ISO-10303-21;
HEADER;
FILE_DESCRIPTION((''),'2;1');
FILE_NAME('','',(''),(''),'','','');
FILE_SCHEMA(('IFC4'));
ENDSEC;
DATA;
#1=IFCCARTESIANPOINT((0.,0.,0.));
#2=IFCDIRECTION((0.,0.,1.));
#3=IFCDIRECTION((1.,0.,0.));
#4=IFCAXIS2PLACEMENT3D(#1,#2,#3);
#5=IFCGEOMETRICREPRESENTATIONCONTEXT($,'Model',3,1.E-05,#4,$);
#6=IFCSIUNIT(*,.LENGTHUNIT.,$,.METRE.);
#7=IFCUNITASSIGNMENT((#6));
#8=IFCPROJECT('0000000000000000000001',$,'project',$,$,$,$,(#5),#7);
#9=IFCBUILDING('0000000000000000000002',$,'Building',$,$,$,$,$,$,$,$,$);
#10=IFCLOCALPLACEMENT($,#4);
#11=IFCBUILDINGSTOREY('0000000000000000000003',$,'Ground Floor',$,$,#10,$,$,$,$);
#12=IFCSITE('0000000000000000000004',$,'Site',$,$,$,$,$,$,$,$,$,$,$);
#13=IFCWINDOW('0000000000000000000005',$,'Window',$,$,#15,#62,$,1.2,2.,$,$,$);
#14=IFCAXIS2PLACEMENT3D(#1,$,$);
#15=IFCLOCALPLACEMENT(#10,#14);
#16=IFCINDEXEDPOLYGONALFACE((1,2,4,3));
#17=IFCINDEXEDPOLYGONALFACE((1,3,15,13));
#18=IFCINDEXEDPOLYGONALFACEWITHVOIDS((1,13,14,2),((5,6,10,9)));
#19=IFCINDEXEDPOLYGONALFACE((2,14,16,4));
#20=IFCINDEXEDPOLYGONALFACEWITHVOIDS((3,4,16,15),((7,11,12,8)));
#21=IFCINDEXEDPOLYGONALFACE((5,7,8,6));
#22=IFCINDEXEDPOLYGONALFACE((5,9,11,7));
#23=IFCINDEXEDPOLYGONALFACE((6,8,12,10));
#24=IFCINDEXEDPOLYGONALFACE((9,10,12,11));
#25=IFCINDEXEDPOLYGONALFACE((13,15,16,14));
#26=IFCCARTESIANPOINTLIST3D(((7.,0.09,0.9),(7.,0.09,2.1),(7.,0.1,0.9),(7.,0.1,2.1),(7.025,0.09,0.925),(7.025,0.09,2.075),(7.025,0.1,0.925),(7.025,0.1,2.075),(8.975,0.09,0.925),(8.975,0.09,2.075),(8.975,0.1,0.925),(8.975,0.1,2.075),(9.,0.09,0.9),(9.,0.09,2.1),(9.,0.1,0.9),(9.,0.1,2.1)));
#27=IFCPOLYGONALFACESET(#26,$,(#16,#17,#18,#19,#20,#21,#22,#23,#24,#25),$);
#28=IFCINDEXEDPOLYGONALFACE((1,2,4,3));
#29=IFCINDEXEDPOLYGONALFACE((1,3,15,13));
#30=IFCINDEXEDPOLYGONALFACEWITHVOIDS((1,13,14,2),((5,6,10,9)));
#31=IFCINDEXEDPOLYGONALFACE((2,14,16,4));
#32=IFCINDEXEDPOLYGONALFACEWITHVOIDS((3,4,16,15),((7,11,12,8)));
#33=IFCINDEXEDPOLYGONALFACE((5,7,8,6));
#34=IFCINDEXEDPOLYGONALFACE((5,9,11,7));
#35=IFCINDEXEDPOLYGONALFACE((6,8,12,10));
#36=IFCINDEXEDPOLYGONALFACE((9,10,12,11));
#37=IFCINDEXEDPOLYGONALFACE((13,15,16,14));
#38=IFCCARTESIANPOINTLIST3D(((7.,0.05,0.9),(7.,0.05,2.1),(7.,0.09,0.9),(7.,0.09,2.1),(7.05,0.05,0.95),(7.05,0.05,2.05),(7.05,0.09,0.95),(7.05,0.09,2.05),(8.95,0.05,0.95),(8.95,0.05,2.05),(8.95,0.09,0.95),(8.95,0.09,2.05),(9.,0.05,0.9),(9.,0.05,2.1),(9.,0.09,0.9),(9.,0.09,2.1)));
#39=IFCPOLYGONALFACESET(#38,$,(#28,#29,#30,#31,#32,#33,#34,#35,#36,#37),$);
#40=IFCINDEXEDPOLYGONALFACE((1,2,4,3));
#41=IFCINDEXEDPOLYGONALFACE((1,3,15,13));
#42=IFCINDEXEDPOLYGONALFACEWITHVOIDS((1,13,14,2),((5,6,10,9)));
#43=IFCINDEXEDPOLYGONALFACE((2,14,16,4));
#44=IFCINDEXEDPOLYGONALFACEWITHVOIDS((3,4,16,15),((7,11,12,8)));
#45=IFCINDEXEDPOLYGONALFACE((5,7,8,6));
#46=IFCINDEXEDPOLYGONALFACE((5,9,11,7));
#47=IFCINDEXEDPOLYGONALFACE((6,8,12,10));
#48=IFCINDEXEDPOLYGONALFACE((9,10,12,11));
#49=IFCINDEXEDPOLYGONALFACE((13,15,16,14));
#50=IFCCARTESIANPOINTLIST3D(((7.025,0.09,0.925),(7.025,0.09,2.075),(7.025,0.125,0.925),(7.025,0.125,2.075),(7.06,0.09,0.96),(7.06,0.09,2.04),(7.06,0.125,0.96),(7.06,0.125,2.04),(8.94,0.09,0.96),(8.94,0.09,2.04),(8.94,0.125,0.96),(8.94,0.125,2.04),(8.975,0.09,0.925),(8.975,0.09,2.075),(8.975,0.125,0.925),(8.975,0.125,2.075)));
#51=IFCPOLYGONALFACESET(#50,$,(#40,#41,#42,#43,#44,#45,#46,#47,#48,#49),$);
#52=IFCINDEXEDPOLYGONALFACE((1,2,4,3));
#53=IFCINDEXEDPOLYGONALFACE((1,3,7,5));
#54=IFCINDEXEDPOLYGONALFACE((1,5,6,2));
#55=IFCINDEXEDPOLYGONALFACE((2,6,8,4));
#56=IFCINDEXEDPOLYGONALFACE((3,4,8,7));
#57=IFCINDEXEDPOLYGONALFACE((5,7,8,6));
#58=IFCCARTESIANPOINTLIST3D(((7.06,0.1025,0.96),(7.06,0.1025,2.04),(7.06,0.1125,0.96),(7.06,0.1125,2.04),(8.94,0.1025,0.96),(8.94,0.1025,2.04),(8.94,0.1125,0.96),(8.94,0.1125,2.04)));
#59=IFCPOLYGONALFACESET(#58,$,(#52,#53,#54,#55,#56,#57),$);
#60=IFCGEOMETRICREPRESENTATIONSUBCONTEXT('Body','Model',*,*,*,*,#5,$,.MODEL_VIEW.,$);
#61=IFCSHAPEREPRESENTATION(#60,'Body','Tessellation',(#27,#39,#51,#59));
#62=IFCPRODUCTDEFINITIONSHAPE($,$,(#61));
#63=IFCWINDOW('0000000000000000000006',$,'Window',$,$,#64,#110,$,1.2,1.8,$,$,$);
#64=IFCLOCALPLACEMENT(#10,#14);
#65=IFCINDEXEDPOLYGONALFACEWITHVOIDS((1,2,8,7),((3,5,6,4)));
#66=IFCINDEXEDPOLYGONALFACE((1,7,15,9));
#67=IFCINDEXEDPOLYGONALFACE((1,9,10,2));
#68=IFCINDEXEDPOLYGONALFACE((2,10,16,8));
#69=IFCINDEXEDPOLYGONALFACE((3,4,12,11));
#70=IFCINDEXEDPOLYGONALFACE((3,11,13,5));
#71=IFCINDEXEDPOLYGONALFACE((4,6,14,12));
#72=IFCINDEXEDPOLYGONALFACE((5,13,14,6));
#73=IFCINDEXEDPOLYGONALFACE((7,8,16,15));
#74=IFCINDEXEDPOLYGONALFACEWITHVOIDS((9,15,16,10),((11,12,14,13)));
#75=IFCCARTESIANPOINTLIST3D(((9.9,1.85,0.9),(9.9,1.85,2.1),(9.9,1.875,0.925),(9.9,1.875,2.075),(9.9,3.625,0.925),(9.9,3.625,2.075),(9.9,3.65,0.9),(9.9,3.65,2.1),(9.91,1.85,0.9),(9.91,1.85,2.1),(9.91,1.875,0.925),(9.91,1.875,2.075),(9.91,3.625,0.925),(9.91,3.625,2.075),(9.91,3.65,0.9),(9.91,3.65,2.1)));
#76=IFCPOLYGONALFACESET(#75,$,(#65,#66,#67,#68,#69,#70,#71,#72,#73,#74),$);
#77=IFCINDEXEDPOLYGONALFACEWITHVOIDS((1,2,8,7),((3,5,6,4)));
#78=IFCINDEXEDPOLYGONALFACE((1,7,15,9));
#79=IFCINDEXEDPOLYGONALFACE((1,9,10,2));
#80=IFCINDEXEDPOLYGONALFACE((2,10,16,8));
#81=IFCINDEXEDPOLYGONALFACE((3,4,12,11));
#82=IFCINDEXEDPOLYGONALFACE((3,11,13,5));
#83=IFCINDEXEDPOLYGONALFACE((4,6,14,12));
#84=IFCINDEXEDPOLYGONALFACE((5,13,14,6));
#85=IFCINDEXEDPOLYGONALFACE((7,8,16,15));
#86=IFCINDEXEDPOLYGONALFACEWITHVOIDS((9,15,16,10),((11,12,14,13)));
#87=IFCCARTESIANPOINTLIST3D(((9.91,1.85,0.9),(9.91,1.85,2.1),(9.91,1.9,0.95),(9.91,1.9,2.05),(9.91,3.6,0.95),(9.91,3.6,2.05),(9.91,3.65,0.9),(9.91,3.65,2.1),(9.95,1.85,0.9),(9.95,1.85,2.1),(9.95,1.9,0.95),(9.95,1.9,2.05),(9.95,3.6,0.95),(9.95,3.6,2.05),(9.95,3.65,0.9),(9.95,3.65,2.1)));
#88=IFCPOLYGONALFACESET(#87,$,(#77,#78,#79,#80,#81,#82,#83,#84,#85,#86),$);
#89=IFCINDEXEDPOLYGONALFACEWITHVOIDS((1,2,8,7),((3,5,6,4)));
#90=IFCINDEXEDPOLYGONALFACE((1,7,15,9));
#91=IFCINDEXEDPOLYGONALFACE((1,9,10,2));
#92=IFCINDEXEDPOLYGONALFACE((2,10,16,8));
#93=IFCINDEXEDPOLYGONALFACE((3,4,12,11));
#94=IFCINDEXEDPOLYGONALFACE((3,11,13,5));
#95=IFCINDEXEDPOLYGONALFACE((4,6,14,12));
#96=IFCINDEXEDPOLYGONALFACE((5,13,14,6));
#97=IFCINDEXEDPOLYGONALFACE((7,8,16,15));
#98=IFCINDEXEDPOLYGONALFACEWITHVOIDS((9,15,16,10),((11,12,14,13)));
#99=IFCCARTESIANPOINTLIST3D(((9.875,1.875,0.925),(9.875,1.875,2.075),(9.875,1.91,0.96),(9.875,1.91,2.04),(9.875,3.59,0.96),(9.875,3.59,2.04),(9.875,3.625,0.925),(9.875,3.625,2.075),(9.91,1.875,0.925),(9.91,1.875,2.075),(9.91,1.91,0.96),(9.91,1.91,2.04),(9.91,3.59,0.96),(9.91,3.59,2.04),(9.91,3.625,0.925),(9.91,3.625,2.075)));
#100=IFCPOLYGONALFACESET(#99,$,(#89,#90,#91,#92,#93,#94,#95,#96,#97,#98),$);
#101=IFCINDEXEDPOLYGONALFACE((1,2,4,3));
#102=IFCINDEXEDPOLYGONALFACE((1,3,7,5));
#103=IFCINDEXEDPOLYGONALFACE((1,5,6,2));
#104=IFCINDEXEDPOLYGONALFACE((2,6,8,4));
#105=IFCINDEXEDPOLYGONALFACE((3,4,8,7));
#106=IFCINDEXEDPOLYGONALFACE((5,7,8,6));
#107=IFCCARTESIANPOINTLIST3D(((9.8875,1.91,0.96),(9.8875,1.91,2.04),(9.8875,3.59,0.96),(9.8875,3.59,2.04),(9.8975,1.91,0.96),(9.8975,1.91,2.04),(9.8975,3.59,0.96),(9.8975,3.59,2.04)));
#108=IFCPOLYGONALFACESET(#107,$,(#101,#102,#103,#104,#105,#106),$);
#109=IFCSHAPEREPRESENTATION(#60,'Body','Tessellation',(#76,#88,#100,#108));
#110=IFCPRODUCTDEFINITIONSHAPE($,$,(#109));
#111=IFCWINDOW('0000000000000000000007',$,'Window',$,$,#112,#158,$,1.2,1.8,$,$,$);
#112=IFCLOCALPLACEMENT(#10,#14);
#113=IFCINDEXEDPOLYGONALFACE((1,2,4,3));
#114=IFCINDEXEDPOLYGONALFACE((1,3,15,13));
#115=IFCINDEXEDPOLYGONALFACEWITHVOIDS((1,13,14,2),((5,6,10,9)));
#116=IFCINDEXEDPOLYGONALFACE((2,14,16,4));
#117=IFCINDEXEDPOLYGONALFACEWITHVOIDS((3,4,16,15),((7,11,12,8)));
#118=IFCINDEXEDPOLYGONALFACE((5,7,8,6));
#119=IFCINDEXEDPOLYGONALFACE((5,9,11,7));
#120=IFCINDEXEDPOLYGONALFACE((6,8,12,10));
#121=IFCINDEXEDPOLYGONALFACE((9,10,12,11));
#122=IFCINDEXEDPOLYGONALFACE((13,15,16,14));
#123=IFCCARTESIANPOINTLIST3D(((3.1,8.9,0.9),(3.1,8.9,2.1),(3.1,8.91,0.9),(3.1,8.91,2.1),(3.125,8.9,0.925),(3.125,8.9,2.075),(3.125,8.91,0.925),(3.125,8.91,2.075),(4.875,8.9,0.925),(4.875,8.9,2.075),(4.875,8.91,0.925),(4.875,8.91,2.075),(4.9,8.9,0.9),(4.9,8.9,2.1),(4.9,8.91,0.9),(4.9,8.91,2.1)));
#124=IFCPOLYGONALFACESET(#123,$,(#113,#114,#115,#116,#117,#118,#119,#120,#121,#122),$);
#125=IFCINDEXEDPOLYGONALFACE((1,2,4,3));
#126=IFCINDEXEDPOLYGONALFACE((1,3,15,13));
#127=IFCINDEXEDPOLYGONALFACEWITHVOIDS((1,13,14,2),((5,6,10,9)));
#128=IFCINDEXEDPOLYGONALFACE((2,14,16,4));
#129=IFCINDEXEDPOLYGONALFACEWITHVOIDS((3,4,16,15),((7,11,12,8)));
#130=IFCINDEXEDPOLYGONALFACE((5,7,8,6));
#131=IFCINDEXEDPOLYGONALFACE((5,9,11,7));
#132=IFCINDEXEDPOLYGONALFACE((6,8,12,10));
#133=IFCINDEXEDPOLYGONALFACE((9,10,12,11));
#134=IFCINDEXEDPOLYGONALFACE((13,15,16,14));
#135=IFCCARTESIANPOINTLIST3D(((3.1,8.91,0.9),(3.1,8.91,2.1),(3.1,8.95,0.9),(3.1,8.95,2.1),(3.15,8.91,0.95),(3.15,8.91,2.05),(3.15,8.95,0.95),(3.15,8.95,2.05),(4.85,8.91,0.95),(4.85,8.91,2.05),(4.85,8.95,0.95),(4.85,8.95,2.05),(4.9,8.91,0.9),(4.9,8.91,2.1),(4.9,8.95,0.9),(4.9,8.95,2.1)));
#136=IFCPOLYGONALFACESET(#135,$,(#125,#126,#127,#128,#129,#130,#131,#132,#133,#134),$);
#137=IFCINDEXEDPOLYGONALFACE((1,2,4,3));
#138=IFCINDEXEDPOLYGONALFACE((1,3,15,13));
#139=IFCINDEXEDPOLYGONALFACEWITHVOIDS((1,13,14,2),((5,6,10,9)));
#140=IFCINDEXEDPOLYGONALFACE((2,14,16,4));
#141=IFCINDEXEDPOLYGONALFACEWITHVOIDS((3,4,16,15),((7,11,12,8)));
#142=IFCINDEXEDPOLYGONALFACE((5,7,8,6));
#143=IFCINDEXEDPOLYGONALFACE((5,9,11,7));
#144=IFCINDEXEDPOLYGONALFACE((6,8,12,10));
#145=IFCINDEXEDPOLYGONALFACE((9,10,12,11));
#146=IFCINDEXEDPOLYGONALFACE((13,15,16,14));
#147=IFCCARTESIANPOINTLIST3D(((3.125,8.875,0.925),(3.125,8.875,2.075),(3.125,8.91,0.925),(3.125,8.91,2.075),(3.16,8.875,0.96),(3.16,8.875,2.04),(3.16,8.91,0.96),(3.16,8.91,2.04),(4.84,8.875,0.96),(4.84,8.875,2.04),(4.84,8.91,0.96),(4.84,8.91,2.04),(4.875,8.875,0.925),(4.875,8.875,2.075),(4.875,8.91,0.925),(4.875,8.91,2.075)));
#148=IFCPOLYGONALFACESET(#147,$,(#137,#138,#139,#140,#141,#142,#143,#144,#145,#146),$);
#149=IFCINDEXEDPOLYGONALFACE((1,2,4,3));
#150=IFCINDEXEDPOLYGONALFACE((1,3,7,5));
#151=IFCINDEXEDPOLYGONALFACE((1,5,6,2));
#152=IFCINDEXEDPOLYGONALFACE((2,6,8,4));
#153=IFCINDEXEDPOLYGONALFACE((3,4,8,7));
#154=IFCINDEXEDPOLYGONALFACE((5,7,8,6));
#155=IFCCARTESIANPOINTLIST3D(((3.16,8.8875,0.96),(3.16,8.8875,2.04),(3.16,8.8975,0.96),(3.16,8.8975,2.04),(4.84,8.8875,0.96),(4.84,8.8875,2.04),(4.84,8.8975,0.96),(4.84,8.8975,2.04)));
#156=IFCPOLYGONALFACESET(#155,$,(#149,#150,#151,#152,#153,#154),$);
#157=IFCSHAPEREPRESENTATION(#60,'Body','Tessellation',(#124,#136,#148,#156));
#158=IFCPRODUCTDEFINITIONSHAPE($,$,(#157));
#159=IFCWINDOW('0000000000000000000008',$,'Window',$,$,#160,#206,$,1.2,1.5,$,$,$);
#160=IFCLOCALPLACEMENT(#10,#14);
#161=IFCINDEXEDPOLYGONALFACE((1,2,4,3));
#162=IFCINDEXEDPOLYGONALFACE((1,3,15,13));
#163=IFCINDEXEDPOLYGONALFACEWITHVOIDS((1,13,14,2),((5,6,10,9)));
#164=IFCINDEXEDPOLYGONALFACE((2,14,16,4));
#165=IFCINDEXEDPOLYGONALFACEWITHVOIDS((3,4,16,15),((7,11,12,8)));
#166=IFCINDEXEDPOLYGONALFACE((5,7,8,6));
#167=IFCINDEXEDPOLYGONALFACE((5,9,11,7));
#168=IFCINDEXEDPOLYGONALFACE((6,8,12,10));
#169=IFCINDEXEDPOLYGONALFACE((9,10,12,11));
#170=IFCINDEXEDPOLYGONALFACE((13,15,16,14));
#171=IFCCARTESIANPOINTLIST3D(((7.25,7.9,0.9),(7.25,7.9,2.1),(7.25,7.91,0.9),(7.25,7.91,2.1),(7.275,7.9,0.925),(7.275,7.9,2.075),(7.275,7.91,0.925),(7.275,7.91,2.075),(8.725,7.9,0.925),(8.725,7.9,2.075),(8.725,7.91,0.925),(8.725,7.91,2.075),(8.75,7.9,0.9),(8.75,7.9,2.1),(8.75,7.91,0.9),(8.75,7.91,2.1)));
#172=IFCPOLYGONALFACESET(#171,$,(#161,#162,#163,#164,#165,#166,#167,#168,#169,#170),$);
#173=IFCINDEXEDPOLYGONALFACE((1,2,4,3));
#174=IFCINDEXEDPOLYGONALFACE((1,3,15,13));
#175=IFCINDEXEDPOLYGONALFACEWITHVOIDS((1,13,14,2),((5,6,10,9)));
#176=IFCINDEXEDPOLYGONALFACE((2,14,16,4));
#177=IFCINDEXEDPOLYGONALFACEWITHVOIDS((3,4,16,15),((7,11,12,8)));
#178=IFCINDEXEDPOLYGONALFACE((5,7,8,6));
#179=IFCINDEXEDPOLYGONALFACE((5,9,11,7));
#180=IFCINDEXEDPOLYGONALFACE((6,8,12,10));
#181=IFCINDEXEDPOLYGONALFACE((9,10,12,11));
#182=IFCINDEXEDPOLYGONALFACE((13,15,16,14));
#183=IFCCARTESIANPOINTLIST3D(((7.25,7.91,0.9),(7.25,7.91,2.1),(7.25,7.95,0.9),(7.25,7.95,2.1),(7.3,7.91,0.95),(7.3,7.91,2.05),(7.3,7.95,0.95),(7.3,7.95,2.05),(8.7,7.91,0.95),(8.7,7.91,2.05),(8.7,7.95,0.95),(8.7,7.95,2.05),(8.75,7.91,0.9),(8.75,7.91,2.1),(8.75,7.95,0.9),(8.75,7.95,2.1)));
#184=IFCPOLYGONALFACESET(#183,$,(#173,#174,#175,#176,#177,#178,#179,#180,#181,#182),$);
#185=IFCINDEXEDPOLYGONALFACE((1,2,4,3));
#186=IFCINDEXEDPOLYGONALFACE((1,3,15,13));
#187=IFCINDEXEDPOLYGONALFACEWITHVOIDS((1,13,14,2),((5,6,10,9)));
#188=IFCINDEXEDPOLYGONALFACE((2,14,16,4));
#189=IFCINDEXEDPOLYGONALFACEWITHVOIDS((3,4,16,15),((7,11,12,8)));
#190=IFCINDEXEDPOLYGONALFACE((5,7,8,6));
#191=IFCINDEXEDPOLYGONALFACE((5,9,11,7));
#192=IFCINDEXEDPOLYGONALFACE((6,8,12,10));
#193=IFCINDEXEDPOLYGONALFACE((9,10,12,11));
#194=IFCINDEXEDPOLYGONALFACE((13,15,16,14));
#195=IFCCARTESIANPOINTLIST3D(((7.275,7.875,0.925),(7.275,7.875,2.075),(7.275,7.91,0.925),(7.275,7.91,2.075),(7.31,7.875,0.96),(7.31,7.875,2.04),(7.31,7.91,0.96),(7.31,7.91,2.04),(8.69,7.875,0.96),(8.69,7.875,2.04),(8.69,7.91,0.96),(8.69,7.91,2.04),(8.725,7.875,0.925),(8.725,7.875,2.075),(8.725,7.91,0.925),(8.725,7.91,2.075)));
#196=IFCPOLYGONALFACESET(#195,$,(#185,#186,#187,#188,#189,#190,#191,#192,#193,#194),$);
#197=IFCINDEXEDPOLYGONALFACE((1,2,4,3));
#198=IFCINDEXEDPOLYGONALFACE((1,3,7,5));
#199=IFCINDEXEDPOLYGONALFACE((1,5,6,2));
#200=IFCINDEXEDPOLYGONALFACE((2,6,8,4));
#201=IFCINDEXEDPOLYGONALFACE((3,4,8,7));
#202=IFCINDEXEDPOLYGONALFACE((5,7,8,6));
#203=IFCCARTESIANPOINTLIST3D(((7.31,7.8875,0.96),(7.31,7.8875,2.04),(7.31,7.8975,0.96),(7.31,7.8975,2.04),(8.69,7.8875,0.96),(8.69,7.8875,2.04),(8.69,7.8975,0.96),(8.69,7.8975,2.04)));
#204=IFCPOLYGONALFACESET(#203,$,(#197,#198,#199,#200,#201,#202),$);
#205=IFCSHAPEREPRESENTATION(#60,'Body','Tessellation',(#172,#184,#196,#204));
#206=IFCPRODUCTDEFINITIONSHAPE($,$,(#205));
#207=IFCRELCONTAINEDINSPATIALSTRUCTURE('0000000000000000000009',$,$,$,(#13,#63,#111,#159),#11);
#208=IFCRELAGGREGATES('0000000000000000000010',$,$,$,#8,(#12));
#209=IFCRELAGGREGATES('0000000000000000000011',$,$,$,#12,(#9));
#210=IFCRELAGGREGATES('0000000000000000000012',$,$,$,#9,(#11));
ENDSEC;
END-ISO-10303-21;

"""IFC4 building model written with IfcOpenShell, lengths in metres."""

from ifc_helpers import new_model, si_unit, frame, origin_with_axes, place, context, subcontext, project, spatial, line, indexed_curve, outline, extrude, element, save


model = new_model("IFC4")

# Units and contexts
model_context = context("Model", 3, precision=1e-05, world=origin_with_axes())
body_context = subcontext(model_context, "Body", "Model", "MODEL_VIEW")
ifc_project = project(units=[si_unit("LENGTHUNIT", "METRE")], contexts=[model_context])

# Site, building, storey
site = spatial("IfcSite", under=ifc_project, Name="Site")
building = spatial("IfcBuilding", under=site, Name="Building")
storey_placement = place(None, origin_with_axes())
storey = spatial("IfcBuildingStorey", under=building, at=storey_placement, Name="Ground Floor")

# Windows
window_1_placement = place(storey_placement, frame((7.0, 0.0, 0.9), z_axis=(0.0, 0.0, 1.0), x_axis=(1.0, 0.0, 0.0)))
element("IfcWindow", 1, at=window_1_placement, inside=storey, Name="Window", OverallHeight=1.2, OverallWidth=2.0, context=body_context, shape_type="SweptSolid", body=[
    extrude(outline(indexed_curve([(0.0, 0.0), (2.0, 0.0), (2.0, 1.2), (0.0, 1.2)], segments=[line(1, 2, 3, 4, 1)]), holes=[indexed_curve([(0.025, 0.025), (1.975, 0.025), (1.975, 1.175), (0.025, 1.175)], segments=[line(1, 2, 3, 4, 1)])]), frame((0.0, 0.09, 0.0), z_axis=(0.0, -1.0, 0.0), x_axis=(1.0, 0.0, 0.0)), (0.0, 0.0, -1.0), 0.01),
    extrude(outline(indexed_curve([(0.0, 0.0), (2.0, 0.0), (2.0, 1.2), (0.0, 1.2)], segments=[line(1, 2, 3, 4, 1)]), holes=[indexed_curve([(0.05, 0.05), (1.95, 0.05), (1.95, 1.15), (0.05, 1.15)], segments=[line(1, 2, 3, 4, 1)])]), frame((0.0, 0.05, 0.0), z_axis=(0.0, -1.0, 0.0), x_axis=(1.0, 0.0, 0.0)), (0.0, 0.0, -1.0), 0.04),
    extrude(outline(indexed_curve([(0.0, 0.0), (1.95, 0.0), (1.95, 1.15), (0.0, 1.15)], segments=[line(1, 2, 3, 4, 1)]), holes=[indexed_curve([(0.035, 0.035), (1.915, 0.035), (1.915, 1.115), (0.035, 1.115)], segments=[line(1, 2, 3, 4, 1)])]), frame((0.025, 0.09, 0.025), z_axis=(0.0, -1.0, 0.0), x_axis=(1.0, 0.0, 0.0)), (0.0, 0.0, -1.0), 0.035),
    extrude(outline(indexed_curve([(0.035, 0.035), (1.915, 0.035), (1.915, 1.115), (0.035, 1.115)], segments=[line(1, 2, 3, 4, 1)])), frame((0.025, 0.1025, 0.025), z_axis=(0.0, -1.0, 0.0), x_axis=(1.0, 0.0, 0.0)), (0.0, 0.0, -1.0), 0.01),
])
for number, where, z_axis, x_axis, name in (
    (2, (10.0, 1.85, 0.9), (0.0, 0.0, 1.0), (0.0, 1.0, 0.0), "Window"),
    (3, (4.9, 9.0, 0.9), (0.0, 0.0, 1.0), (-1.0, 0.0, 0.0), "Window"),
):
    element("IfcWindow", number, at=place(storey_placement, frame(where, z_axis=z_axis, x_axis=x_axis)), inside=storey, Name=name, OverallHeight=1.2, OverallWidth=1.8, context=body_context, shape_type="SweptSolid", body=[
        extrude(outline(indexed_curve([(0.0, 0.0), (1.8, 0.0), (1.8, 1.2), (0.0, 1.2)], segments=[line(1, 2, 3, 4, 1)]), holes=[indexed_curve([(0.025, 0.025), (1.775, 0.025), (1.775, 1.175), (0.025, 1.175)], segments=[line(1, 2, 3, 4, 1)])]), frame((0.0, 0.09, 0.0), z_axis=(0.0, -1.0, 0.0), x_axis=(1.0, 0.0, 0.0)), (0.0, 0.0, -1.0), 0.01),
        extrude(outline(indexed_curve([(0.0, 0.0), (1.8, 0.0), (1.8, 1.2), (0.0, 1.2)], segments=[line(1, 2, 3, 4, 1)]), holes=[indexed_curve([(0.05, 0.05), (1.75, 0.05), (1.75, 1.15), (0.05, 1.15)], segments=[line(1, 2, 3, 4, 1)])]), frame((0.0, 0.05, 0.0), z_axis=(0.0, -1.0, 0.0), x_axis=(1.0, 0.0, 0.0)), (0.0, 0.0, -1.0), 0.04),
        extrude(outline(indexed_curve([(0.0, 0.0), (1.75, 0.0), (1.75, 1.15), (0.0, 1.15)], segments=[line(1, 2, 3, 4, 1)]), holes=[indexed_curve([(0.035, 0.035), (1.715, 0.035), (1.715, 1.115), (0.035, 1.115)], segments=[line(1, 2, 3, 4, 1)])]), frame((0.025, 0.09, 0.025), z_axis=(0.0, -1.0, 0.0), x_axis=(1.0, 0.0, 0.0)), (0.0, 0.0, -1.0), 0.035),
        extrude(outline(indexed_curve([(0.035, 0.035), (1.715, 0.035), (1.715, 1.115), (0.035, 1.115)], segments=[line(1, 2, 3, 4, 1)])), frame((0.025, 0.1025, 0.025), z_axis=(0.0, -1.0, 0.0), x_axis=(1.0, 0.0, 0.0)), (0.0, 0.0, -1.0), 0.01),
    ])
window_2_placement = place(storey_placement, frame((8.75, 8.0, 0.9), z_axis=(0.0, 0.0, 1.0), x_axis=(-1.0, 0.0, 0.0)))
element("IfcWindow", 4, at=window_2_placement, inside=storey, Name="Window", OverallHeight=1.2, OverallWidth=1.5, context=body_context, shape_type="SweptSolid", body=[
    extrude(outline(indexed_curve([(0.0, 0.0), (1.5, 0.0), (1.5, 1.2), (0.0, 1.2)], segments=[line(1, 2, 3, 4, 1)]), holes=[indexed_curve([(0.025, 0.025), (1.475, 0.025), (1.475, 1.175), (0.025, 1.175)], segments=[line(1, 2, 3, 4, 1)])]), frame((0.0, 0.09, 0.0), z_axis=(0.0, -1.0, 0.0), x_axis=(1.0, 0.0, 0.0)), (0.0, 0.0, -1.0), 0.01),
    extrude(outline(indexed_curve([(0.0, 0.0), (1.5, 0.0), (1.5, 1.2), (0.0, 1.2)], segments=[line(1, 2, 3, 4, 1)]), holes=[indexed_curve([(0.05, 0.05), (1.45, 0.05), (1.45, 1.15), (0.05, 1.15)], segments=[line(1, 2, 3, 4, 1)])]), frame((0.0, 0.05, 0.0), z_axis=(0.0, -1.0, 0.0), x_axis=(1.0, 0.0, 0.0)), (0.0, 0.0, -1.0), 0.04),
    extrude(outline(indexed_curve([(0.0, 0.0), (1.45, 0.0), (1.45, 1.15), (0.0, 1.15)], segments=[line(1, 2, 3, 4, 1)]), holes=[indexed_curve([(0.035, 0.035), (1.415, 0.035), (1.415, 1.115), (0.035, 1.115)], segments=[line(1, 2, 3, 4, 1)])]), frame((0.025, 0.09, 0.025), z_axis=(0.0, -1.0, 0.0), x_axis=(1.0, 0.0, 0.0)), (0.0, 0.0, -1.0), 0.035),
    extrude(outline(indexed_curve([(0.035, 0.035), (1.415, 0.035), (1.415, 1.115), (0.035, 1.115)], segments=[line(1, 2, 3, 4, 1)])), frame((0.025, 0.1025, 0.025), z_axis=(0.0, -1.0, 0.0), x_axis=(1.0, 0.0, 0.0)), (0.0, 0.0, -1.0), 0.01),
])

save(model, "model.ifc")
